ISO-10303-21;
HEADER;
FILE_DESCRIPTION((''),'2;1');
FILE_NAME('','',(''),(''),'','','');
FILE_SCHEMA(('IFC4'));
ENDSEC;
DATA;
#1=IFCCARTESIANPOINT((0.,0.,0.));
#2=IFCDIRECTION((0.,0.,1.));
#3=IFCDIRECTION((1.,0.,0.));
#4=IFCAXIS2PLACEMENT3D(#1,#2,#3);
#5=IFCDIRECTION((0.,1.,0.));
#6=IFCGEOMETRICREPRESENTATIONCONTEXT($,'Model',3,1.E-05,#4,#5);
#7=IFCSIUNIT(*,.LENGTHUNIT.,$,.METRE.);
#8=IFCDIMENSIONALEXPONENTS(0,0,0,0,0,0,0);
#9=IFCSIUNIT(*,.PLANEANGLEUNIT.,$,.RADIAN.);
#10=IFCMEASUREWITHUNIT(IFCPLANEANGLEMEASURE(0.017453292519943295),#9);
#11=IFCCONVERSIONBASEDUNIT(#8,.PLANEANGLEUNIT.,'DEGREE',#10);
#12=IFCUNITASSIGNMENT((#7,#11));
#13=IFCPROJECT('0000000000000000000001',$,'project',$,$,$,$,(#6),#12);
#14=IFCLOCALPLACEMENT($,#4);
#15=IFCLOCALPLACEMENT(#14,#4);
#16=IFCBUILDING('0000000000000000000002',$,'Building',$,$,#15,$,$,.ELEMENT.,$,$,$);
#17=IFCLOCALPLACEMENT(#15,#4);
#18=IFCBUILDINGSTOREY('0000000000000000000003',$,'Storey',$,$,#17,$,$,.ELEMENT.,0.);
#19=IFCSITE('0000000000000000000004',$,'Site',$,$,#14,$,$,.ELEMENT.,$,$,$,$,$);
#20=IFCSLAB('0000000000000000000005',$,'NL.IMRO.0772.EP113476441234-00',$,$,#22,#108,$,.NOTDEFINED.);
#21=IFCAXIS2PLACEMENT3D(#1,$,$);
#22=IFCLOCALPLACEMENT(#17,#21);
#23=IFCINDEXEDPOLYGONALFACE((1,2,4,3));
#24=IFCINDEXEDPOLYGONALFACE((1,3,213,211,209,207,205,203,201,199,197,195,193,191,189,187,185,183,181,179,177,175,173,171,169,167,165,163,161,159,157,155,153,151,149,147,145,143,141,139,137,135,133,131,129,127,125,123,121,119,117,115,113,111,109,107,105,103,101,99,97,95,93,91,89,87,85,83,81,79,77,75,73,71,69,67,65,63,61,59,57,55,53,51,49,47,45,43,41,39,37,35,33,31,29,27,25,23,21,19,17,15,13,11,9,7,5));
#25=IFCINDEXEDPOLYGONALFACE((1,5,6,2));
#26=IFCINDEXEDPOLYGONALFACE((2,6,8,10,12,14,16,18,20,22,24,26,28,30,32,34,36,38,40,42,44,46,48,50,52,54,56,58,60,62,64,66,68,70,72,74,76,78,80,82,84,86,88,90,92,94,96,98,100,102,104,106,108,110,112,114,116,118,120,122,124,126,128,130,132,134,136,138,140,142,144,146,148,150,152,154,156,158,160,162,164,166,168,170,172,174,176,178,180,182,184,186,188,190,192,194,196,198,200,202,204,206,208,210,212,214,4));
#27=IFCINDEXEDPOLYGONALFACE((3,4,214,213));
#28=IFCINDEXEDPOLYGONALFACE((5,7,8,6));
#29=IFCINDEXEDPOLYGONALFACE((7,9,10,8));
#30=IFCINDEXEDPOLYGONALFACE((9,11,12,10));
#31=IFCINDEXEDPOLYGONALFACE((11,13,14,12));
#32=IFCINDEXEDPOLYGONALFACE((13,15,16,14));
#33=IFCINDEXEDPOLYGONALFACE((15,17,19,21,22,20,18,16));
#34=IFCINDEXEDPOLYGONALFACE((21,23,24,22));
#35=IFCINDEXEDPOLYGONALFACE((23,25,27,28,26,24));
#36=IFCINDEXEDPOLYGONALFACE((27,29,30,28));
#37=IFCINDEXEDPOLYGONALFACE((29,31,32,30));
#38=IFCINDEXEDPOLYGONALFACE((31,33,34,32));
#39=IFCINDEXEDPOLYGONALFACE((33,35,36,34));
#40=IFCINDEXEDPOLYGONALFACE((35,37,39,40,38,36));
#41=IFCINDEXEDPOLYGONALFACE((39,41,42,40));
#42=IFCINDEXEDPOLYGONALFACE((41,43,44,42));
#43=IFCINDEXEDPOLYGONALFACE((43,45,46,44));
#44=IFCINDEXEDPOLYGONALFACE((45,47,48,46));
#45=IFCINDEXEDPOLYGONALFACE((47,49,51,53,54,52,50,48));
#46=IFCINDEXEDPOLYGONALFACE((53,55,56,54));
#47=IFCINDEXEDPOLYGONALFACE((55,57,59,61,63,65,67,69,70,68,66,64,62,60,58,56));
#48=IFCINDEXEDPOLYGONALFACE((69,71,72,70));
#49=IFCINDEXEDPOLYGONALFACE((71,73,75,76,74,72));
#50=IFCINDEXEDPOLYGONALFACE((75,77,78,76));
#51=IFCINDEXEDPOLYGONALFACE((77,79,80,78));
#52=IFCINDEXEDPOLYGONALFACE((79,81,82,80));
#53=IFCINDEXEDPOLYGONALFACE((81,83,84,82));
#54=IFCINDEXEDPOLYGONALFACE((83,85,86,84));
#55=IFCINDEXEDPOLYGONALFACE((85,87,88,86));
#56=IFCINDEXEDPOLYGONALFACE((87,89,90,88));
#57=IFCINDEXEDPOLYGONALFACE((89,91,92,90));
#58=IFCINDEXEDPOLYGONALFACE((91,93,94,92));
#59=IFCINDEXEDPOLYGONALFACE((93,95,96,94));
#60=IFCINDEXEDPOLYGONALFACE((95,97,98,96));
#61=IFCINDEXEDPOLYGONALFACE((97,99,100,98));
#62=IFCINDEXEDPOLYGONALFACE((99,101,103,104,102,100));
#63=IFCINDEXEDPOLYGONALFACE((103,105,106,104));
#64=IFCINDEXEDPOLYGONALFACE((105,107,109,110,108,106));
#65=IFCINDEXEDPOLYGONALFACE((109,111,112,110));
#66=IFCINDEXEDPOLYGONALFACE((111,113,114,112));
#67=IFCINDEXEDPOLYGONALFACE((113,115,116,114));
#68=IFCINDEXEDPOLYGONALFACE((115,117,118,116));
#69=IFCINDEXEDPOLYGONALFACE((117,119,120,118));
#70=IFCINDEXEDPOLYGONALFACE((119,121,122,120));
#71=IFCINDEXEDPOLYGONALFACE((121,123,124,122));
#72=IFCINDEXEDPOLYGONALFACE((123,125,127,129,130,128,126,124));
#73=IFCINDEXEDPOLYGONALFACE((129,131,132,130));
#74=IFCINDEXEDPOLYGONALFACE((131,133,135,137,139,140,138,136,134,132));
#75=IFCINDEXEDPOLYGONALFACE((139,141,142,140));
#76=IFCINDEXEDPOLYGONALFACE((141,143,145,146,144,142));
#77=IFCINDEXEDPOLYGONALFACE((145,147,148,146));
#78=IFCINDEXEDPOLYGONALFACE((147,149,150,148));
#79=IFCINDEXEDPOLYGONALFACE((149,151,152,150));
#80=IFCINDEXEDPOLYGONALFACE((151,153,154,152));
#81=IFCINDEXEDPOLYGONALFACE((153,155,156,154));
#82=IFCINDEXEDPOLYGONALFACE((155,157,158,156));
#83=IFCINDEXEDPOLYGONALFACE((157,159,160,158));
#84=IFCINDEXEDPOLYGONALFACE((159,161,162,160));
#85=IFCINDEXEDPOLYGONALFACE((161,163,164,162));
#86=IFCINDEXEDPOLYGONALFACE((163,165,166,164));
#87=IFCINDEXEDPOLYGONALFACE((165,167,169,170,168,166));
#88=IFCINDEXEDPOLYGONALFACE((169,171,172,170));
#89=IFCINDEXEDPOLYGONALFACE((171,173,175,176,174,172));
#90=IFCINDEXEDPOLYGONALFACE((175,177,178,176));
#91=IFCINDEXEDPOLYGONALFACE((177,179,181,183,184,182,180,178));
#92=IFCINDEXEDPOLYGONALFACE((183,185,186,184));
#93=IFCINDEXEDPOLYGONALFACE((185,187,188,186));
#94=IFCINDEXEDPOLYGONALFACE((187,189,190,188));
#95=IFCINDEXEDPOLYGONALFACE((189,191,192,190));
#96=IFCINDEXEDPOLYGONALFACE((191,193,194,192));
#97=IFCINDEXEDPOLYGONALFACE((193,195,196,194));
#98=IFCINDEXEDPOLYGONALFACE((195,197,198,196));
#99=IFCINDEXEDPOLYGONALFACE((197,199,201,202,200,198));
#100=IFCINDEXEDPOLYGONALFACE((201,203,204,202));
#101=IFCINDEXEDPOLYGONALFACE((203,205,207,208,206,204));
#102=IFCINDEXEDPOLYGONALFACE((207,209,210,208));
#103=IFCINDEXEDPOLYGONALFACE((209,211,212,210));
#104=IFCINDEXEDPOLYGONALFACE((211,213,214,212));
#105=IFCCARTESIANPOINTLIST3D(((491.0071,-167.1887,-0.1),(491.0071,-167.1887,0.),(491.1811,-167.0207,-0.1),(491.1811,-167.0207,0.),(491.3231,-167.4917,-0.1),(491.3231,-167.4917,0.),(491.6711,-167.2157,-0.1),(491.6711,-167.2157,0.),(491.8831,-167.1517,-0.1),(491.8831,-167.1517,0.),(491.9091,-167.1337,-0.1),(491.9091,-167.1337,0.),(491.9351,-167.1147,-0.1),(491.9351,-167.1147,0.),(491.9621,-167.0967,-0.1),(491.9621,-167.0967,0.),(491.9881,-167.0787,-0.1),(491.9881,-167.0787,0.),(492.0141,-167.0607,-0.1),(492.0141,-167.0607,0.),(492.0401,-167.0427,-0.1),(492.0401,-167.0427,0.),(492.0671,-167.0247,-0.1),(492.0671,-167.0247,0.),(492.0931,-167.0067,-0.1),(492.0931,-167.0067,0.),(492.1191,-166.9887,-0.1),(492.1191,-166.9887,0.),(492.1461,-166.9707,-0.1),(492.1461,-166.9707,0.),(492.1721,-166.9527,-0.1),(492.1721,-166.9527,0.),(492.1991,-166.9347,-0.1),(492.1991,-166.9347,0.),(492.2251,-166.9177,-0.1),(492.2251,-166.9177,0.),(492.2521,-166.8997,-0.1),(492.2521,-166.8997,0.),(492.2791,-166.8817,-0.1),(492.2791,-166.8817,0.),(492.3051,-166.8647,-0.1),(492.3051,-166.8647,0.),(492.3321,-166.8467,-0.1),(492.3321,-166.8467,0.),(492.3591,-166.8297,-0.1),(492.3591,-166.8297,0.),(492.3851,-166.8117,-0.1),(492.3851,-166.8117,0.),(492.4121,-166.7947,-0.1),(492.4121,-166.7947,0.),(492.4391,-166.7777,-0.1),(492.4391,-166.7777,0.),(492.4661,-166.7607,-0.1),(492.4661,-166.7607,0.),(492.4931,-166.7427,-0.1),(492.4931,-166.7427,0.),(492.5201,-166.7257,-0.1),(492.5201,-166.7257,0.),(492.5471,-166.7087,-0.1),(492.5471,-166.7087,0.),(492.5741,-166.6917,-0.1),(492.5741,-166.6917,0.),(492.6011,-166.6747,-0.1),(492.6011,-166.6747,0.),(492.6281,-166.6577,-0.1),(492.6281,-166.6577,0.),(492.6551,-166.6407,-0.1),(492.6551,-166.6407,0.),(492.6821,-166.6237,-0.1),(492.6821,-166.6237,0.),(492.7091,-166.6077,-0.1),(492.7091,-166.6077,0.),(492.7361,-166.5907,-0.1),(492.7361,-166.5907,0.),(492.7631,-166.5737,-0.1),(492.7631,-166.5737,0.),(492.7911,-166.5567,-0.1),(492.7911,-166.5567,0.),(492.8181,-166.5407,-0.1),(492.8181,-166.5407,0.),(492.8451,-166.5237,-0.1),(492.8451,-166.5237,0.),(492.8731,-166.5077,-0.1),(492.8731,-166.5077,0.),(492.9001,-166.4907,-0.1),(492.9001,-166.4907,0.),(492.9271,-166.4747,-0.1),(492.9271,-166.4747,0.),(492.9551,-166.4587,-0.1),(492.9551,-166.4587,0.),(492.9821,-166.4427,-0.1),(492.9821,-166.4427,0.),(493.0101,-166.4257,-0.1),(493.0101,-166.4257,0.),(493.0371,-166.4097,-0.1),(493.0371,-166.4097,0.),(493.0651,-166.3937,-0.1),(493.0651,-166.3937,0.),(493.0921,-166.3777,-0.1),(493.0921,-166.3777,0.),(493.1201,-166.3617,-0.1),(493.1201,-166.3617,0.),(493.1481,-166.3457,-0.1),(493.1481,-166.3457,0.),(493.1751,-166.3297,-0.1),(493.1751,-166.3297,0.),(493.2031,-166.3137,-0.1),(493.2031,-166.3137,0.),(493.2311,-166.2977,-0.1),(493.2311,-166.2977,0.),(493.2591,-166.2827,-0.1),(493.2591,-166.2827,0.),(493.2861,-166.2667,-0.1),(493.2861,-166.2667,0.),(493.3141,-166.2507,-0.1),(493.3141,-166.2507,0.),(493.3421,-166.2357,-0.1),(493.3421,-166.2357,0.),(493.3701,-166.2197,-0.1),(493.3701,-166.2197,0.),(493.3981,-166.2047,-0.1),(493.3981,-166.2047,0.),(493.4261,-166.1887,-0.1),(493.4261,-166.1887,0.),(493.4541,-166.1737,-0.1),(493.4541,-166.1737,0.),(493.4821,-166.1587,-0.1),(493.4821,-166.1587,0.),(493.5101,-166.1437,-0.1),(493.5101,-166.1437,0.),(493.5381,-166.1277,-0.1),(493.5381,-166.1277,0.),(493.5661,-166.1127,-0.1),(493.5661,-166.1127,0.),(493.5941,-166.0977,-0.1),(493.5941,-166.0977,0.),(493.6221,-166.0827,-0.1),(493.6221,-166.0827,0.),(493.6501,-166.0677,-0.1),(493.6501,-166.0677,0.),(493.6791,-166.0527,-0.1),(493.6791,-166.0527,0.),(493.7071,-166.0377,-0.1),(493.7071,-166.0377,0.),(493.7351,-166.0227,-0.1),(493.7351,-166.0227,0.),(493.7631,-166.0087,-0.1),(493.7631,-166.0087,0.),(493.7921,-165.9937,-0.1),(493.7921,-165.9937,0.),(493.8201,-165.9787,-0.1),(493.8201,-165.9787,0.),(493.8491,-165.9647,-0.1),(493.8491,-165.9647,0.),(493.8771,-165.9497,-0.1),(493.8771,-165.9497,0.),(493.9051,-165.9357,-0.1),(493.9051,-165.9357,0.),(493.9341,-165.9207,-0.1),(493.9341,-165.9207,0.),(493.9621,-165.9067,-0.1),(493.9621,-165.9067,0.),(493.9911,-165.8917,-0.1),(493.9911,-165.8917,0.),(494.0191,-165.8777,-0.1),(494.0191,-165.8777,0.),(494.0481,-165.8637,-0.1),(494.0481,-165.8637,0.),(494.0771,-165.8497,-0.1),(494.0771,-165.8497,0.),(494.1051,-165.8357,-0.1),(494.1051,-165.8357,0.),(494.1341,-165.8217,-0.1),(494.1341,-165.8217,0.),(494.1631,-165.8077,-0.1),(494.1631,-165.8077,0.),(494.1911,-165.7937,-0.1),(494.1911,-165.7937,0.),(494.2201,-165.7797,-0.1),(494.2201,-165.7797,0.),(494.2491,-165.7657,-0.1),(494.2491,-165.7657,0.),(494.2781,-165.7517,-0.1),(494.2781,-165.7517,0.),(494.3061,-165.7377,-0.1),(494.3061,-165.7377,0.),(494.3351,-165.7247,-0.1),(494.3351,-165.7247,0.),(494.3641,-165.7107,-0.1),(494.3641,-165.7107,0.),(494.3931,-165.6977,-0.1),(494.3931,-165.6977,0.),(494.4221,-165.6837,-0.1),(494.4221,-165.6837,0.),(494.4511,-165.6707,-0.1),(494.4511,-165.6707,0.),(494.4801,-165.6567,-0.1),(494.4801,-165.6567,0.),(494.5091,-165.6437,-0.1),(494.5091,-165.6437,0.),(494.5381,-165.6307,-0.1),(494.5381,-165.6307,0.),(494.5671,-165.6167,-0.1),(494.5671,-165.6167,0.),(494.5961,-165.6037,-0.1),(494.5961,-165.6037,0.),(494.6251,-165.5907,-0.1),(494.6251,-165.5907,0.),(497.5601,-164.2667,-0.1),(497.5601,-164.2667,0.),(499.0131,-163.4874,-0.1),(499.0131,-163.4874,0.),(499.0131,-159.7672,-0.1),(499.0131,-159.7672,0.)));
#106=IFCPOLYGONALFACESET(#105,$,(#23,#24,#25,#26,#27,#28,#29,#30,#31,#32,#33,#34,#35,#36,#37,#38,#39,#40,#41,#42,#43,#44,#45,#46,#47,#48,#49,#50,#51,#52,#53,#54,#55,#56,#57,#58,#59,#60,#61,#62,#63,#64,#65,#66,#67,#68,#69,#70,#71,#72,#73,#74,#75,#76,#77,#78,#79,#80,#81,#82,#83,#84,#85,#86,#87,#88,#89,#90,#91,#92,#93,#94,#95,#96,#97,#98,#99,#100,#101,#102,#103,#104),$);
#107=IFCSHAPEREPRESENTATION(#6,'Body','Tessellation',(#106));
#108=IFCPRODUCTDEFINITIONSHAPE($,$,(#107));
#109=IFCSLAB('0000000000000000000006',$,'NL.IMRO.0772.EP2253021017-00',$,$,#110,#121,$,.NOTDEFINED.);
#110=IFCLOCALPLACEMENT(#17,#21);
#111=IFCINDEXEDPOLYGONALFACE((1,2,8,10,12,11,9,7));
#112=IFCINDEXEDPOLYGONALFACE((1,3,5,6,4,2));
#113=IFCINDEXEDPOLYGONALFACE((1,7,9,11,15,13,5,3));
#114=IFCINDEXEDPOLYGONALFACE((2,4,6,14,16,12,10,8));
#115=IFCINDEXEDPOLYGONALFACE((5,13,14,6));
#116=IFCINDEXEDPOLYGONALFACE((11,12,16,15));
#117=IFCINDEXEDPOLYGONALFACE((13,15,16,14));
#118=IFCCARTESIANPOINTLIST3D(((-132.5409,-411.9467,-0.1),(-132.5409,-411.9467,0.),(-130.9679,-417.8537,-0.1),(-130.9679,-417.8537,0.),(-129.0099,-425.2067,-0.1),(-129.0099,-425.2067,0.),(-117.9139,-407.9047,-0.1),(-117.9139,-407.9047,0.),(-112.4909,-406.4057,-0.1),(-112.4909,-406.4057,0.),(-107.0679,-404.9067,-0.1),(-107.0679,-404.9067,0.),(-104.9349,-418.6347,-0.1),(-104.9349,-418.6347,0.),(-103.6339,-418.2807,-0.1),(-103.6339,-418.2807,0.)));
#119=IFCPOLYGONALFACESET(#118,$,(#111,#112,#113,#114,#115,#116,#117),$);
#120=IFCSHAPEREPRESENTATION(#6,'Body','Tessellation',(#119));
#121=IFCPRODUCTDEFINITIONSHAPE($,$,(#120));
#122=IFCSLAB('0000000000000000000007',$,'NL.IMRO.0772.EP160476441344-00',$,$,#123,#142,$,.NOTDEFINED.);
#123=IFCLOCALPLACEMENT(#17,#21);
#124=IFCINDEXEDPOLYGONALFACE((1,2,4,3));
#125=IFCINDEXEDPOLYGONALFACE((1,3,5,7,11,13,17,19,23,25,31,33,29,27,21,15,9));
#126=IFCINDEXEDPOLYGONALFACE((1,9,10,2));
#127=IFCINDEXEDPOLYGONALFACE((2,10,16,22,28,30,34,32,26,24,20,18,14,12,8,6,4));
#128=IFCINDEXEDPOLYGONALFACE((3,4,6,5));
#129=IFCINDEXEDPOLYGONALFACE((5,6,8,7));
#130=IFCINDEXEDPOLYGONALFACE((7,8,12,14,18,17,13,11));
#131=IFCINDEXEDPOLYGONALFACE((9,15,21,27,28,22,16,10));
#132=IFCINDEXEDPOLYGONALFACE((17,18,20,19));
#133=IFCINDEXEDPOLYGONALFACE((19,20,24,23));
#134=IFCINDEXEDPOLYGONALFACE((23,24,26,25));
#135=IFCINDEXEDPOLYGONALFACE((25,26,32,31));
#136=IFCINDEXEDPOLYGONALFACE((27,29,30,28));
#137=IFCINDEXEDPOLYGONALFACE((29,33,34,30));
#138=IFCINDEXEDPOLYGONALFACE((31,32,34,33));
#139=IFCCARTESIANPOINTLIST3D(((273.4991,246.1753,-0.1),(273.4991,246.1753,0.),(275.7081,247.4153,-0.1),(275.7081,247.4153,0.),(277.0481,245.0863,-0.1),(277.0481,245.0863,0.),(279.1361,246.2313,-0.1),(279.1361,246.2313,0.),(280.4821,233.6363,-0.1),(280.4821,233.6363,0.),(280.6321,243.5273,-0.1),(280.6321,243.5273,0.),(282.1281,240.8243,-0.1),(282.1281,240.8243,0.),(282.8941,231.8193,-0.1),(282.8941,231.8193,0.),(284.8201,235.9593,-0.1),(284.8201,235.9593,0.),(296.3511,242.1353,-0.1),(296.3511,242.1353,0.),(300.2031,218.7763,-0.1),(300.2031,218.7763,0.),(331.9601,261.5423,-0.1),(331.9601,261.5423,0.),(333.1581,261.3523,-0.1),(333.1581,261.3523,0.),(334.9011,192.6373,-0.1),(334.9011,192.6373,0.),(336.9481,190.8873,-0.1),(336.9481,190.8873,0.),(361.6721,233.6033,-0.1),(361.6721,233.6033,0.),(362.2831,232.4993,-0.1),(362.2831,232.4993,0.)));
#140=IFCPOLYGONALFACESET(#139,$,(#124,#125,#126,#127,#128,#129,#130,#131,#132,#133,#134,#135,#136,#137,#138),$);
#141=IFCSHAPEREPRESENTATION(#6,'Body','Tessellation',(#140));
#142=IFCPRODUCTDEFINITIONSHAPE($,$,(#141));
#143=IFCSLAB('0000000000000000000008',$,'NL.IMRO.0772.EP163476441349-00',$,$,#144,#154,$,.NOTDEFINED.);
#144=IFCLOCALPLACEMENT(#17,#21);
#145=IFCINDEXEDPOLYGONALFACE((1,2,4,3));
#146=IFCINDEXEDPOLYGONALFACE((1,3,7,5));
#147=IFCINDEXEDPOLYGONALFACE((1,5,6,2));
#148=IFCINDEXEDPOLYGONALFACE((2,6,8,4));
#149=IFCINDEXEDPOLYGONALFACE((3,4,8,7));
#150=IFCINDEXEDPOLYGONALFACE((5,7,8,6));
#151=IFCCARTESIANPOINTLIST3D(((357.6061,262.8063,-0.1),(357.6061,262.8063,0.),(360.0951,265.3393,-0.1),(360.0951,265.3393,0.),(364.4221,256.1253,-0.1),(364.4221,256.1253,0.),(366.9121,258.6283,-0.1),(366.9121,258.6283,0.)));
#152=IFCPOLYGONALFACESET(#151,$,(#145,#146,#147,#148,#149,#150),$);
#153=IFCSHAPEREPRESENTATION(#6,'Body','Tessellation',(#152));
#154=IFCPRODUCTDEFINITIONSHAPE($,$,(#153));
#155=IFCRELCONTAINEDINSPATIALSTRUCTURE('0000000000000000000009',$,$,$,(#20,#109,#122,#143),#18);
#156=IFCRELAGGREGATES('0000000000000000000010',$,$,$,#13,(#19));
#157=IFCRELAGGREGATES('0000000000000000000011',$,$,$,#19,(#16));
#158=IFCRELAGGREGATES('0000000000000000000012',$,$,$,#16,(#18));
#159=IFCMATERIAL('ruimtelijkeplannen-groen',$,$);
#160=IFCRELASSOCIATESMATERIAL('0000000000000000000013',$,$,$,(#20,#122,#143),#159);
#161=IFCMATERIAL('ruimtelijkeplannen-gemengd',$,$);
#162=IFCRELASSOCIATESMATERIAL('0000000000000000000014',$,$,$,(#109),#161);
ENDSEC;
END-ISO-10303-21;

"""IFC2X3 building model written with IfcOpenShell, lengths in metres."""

from ifc_helpers import new_model, entity, si_unit, converted_unit, direction, frame, origin_with_axes, place, context, project, spatial, polyline, outline, extrude, material, element, save


model = new_model("IFC2X3")

# Units and contexts
model_context = context("Model", 3, precision=1e-05, world=origin_with_axes(), true_north=direction((0.0, 1.0, 0.0)))
ifc_project = project(units=[si_unit("LENGTHUNIT", "METRE"), converted_unit("PLANEANGLEUNIT", "DEGREE", entity("IfcPlaneAngleMeasure", 0.017453292519943295), si_unit("PLANEANGLEUNIT", "RADIAN"), dimensions=[0, 0, 0, 0, 0, 0, 0])], contexts=[model_context])

# Site, building, storey
site_placement = place(None, origin_with_axes())
site = spatial("IfcSite", under=ifc_project, at=site_placement, Name="Site", CompositionType="ELEMENT")
building_placement = place(site_placement, origin_with_axes())
building = spatial("IfcBuilding", under=site, at=building_placement, Name="Building", CompositionType="ELEMENT")
storey_placement = place(building_placement, origin_with_axes())
storey = spatial("IfcBuildingStorey", under=building, at=storey_placement, Name="Storey", CompositionType="ELEMENT", Elevation=0.0)

# Slabs
ifc_material_1 = material(Name="ruimtelijkeplannen-groen")
slab_1_placement = place(storey_placement, frame((0.0, 0.0, -0.1), z_axis=(0.0, 0.0, 1.0), x_axis=(1.0, 0.0, 0.0)))
element("IfcSlab", 1, at=slab_1_placement, inside=storey, material=ifc_material_1, Name="NL.IMRO.0772.EP113476441234-00", PredefinedType="NOTDEFINED", context=model_context, shape_type="SweptSolid", body=[
    extrude(outline(polyline([(497.5601, -164.2667), (494.6251, -165.5907), (494.5961, -165.6037), (494.5671, -165.6167), (494.5381, -165.6307), (494.5091, -165.6437), (494.4801, -165.6567), (494.4511, -165.6707), (494.4221, -165.6837), (494.3931, -165.6977), (494.3641, -165.7107), (494.3351, -165.7247), (494.3061, -165.7377), (494.2781, -165.7517), (494.2491, -165.7657), (494.2201, -165.7797), (494.1911, -165.7937), (494.1631, -165.8077), (494.1341, -165.8217), (494.1051, -165.8357), (494.0771, -165.8497), (494.0481, -165.8637), (494.0191, -165.8777), (493.9911, -165.8917), (493.9621, -165.9067), (493.9341, -165.9207), (493.9051, -165.9357), (493.8771, -165.9497), (493.8491, -165.9647), (493.8201, -165.9787), (493.7921, -165.9937), (493.7631, -166.0087), (493.7351, -166.0227), (493.7071, -166.0377), (493.6791, -166.0527), (493.6501, -166.0677), (493.6221, -166.0827), (493.5941, -166.0977), (493.5661, -166.1127), (493.5381, -166.1277), (493.5101, -166.1437), (493.4821, -166.1587), (493.4541, -166.1737), (493.4261, -166.1887), (493.3981, -166.2047), (493.3701, -166.2197), (493.3421, -166.2357), (493.3141, -166.2507), (493.2861, -166.2667), (493.2591, -166.2827), (493.2311, -166.2977), (493.2031, -166.3137), (493.1751, -166.3297), (493.1481, -166.3457), (493.1201, -166.3617), (493.0921, -166.3777), (493.0651, -166.3937), (493.0371, -166.4097), (493.0101, -166.4257), (492.9821, -166.4427), (492.9551, -166.4587), (492.9271, -166.4747), (492.9001, -166.4907), (492.8731, -166.5077), (492.8451, -166.5237), (492.8181, -166.5407), (492.7911, -166.5567), (492.7631, -166.5737), (492.7361, -166.5907), (492.7091, -166.6077), (492.6821, -166.6237), (492.6551, -166.6407), (492.6281, -166.6577), (492.6011, -166.6747), (492.5741, -166.6917), (492.5471, -166.7087), (492.5201, -166.7257), (492.4931, -166.7427), (492.4661, -166.7607), (492.4391, -166.7777), (492.4121, -166.7947), (492.3851, -166.8117), (492.3591, -166.8297), (492.3321, -166.8467), (492.3051, -166.8647), (492.2791, -166.8817), (492.2521, -166.8997), (492.2251, -166.9177), (492.1991, -166.9347), (492.1721, -166.9527), (492.1461, -166.9707), (492.1191, -166.9887), (492.0931, -167.0067), (492.0671, -167.0247), (492.0401, -167.0427), (492.0141, -167.0607), (491.9881, -167.0787), (491.9621, -167.0967), (491.9351, -167.1147), (491.9091, -167.1337), (491.8831, -167.1517), (491.6711, -167.2157), (491.3231, -167.4917), (491.0071, -167.1887), (491.1811, -167.0207), (499.0131, -159.7672), (499.0131, -163.4874), (497.5601, -164.2667)])), origin_with_axes(), (0.0, 0.0, 1.0), 0.1),
])
ifc_material_2 = material(Name="ruimtelijkeplannen-gemengd")
slab_2_placement = place(storey_placement, frame((0.0, 0.0, -0.1), z_axis=(0.0, 0.0, 1.0), x_axis=(1.0, 0.0, 0.0)))
element("IfcSlab", 2, at=slab_2_placement, inside=storey, material=ifc_material_2, Name="NL.IMRO.0772.EP2253021017-00", PredefinedType="NOTDEFINED", context=model_context, shape_type="SweptSolid", body=[
    extrude(outline(polyline([(-132.5409, -411.9467), (-117.9139, -407.9047), (-112.4909, -406.4057), (-107.0679, -404.9067), (-103.6339, -418.2807), (-104.9349, -418.6347), (-129.0099, -425.2067), (-130.9679, -417.8537), (-132.5409, -411.9467)])), origin_with_axes(), (0.0, 0.0, 1.0), 0.1),
])
slab_3_placement = place(storey_placement, frame((0.0, 0.0, -0.1), z_axis=(0.0, 0.0, 1.0), x_axis=(1.0, 0.0, 0.0)))
element("IfcSlab", 3, at=slab_3_placement, inside=storey, material=ifc_material_1, Name="NL.IMRO.0772.EP160476441344-00", PredefinedType="NOTDEFINED", context=model_context, shape_type="SweptSolid", body=[
    extrude(outline(polyline([(334.9011, 192.6373), (300.2031, 218.7763), (282.8941, 231.8193), (280.4821, 233.6363), (273.4991, 246.1753), (275.7081, 247.4153), (277.0481, 245.0863), (279.1361, 246.2313), (280.6321, 243.5273), (282.1281, 240.8243), (284.8201, 235.9593), (296.3511, 242.1353), (331.9601, 261.5423), (333.1581, 261.3523), (361.6721, 233.6033), (362.2831, 232.4993), (336.9481, 190.8873), (334.9011, 192.6373)])), origin_with_axes(), (0.0, 0.0, 1.0), 0.1),
])
slab_4_placement = place(storey_placement, frame((0.0, 0.0, -0.1), z_axis=(0.0, 0.0, 1.0), x_axis=(1.0, 0.0, 0.0)))
element("IfcSlab", 4, at=slab_4_placement, inside=storey, material=ifc_material_1, Name="NL.IMRO.0772.EP163476441349-00", PredefinedType="NOTDEFINED", context=model_context, shape_type="SweptSolid", body=[
    extrude(outline(polyline([(357.6061, 262.8063), (360.0951, 265.3393), (366.9121, 258.6283), (364.4221, 256.1253), (357.6061, 262.8063)])), origin_with_axes(), (0.0, 0.0, 1.0), 0.1),
])

save(model, "model.ifc")
